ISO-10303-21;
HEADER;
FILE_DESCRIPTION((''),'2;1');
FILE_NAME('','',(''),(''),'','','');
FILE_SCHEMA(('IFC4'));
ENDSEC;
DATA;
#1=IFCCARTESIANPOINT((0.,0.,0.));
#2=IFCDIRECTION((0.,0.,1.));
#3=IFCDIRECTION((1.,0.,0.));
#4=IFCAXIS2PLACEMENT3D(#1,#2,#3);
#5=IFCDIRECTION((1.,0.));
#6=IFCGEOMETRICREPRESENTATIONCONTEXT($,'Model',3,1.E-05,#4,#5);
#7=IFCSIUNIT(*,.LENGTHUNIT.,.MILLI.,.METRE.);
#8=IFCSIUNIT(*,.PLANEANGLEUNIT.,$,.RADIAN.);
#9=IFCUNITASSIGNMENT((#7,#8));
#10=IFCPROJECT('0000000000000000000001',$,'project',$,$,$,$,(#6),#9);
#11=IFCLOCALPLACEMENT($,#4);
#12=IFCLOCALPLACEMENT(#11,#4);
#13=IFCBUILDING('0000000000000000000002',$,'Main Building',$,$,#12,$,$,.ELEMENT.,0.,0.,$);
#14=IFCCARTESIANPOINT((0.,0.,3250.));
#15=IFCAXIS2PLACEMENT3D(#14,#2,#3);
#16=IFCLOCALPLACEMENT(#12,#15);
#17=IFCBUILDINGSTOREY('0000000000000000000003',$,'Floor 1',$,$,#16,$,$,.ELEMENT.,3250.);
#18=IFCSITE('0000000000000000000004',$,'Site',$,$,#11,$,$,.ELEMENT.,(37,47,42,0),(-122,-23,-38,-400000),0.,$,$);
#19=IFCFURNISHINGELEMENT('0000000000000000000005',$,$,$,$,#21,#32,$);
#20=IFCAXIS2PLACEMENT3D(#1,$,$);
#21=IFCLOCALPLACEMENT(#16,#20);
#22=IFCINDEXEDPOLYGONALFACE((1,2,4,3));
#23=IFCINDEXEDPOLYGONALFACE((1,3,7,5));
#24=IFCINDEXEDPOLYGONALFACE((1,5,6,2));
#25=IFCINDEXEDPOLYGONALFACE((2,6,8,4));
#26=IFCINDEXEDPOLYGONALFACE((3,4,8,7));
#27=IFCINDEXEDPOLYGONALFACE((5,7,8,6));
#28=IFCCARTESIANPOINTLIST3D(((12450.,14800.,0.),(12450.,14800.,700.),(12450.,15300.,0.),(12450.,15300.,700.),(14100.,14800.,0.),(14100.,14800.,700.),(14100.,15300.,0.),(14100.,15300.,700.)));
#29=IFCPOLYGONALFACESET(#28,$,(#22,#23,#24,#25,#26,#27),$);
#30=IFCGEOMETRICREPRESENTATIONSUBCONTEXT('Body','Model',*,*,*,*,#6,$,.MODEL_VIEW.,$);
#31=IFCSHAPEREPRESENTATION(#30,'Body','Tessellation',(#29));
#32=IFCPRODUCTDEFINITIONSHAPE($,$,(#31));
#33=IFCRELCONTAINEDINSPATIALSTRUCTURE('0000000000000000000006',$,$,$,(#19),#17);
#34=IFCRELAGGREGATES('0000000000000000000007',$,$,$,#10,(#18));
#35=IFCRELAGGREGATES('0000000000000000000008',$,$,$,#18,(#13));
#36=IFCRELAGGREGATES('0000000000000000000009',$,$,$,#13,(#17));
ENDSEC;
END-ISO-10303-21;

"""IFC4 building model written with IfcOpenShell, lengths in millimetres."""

from ifc_helpers import new_model, si_unit, direction, frame, origin_with_axes, origin_2d_with_axis, place, context, subcontext, project, spatial, rectangle, extrude, element, save


model = new_model("IFC4")

# Units and contexts
model_context = context("Model", 3, precision=1e-05, world=origin_with_axes(), true_north=direction((1.0, 0.0)))
body_context = subcontext(model_context, "Body", "Model", "MODEL_VIEW")
ifc_project = project(units=[si_unit("LENGTHUNIT", "METRE", prefix="MILLI"), si_unit("PLANEANGLEUNIT", "RADIAN")], contexts=[model_context])

# Site, building, storey
site_placement = place(None, origin_with_axes())
site = spatial("IfcSite", under=ifc_project, at=site_placement, Name="Site", CompositionType="ELEMENT", RefLatitude=(37, 47, 42, 0), RefLongitude=(-122, -23, -38, -400000), RefElevation=0.0)
building_placement = place(site_placement, origin_with_axes())
building = spatial("IfcBuilding", under=site, at=building_placement, Name="Main Building", CompositionType="ELEMENT", ElevationOfRefHeight=0.0, ElevationOfTerrain=0.0)
storey_placement = place(building_placement, frame((0.0, 0.0, 3250.0), z_axis=(0.0, 0.0, 1.0), x_axis=(1.0, 0.0, 0.0)))
storey = spatial("IfcBuildingStorey", under=building, at=storey_placement, Name="Floor 1", CompositionType="ELEMENT", Elevation=3250.0)

# Furnishing element
furnishing_placement = place(storey_placement, frame((12450.0, 14800.0, 0.0), z_axis=(0.0, 0.0, 1.0), x_axis=(1.0, 0.0, 0.0)))
element("IfcFurnishingElement", 1, at=furnishing_placement, inside=storey, context=body_context, shape_type="SweptSolid", body=[
    extrude(rectangle(XDim=1650.0, YDim=500.0, at=origin_2d_with_axis()), frame((825.0, 250.0, 0.0), z_axis=(0.0, 0.0, 1.0), x_axis=(1.0, 0.0, 0.0)), (0.0, 0.0, 1.0), 700.0),
])

save(model, "model.ifc")
